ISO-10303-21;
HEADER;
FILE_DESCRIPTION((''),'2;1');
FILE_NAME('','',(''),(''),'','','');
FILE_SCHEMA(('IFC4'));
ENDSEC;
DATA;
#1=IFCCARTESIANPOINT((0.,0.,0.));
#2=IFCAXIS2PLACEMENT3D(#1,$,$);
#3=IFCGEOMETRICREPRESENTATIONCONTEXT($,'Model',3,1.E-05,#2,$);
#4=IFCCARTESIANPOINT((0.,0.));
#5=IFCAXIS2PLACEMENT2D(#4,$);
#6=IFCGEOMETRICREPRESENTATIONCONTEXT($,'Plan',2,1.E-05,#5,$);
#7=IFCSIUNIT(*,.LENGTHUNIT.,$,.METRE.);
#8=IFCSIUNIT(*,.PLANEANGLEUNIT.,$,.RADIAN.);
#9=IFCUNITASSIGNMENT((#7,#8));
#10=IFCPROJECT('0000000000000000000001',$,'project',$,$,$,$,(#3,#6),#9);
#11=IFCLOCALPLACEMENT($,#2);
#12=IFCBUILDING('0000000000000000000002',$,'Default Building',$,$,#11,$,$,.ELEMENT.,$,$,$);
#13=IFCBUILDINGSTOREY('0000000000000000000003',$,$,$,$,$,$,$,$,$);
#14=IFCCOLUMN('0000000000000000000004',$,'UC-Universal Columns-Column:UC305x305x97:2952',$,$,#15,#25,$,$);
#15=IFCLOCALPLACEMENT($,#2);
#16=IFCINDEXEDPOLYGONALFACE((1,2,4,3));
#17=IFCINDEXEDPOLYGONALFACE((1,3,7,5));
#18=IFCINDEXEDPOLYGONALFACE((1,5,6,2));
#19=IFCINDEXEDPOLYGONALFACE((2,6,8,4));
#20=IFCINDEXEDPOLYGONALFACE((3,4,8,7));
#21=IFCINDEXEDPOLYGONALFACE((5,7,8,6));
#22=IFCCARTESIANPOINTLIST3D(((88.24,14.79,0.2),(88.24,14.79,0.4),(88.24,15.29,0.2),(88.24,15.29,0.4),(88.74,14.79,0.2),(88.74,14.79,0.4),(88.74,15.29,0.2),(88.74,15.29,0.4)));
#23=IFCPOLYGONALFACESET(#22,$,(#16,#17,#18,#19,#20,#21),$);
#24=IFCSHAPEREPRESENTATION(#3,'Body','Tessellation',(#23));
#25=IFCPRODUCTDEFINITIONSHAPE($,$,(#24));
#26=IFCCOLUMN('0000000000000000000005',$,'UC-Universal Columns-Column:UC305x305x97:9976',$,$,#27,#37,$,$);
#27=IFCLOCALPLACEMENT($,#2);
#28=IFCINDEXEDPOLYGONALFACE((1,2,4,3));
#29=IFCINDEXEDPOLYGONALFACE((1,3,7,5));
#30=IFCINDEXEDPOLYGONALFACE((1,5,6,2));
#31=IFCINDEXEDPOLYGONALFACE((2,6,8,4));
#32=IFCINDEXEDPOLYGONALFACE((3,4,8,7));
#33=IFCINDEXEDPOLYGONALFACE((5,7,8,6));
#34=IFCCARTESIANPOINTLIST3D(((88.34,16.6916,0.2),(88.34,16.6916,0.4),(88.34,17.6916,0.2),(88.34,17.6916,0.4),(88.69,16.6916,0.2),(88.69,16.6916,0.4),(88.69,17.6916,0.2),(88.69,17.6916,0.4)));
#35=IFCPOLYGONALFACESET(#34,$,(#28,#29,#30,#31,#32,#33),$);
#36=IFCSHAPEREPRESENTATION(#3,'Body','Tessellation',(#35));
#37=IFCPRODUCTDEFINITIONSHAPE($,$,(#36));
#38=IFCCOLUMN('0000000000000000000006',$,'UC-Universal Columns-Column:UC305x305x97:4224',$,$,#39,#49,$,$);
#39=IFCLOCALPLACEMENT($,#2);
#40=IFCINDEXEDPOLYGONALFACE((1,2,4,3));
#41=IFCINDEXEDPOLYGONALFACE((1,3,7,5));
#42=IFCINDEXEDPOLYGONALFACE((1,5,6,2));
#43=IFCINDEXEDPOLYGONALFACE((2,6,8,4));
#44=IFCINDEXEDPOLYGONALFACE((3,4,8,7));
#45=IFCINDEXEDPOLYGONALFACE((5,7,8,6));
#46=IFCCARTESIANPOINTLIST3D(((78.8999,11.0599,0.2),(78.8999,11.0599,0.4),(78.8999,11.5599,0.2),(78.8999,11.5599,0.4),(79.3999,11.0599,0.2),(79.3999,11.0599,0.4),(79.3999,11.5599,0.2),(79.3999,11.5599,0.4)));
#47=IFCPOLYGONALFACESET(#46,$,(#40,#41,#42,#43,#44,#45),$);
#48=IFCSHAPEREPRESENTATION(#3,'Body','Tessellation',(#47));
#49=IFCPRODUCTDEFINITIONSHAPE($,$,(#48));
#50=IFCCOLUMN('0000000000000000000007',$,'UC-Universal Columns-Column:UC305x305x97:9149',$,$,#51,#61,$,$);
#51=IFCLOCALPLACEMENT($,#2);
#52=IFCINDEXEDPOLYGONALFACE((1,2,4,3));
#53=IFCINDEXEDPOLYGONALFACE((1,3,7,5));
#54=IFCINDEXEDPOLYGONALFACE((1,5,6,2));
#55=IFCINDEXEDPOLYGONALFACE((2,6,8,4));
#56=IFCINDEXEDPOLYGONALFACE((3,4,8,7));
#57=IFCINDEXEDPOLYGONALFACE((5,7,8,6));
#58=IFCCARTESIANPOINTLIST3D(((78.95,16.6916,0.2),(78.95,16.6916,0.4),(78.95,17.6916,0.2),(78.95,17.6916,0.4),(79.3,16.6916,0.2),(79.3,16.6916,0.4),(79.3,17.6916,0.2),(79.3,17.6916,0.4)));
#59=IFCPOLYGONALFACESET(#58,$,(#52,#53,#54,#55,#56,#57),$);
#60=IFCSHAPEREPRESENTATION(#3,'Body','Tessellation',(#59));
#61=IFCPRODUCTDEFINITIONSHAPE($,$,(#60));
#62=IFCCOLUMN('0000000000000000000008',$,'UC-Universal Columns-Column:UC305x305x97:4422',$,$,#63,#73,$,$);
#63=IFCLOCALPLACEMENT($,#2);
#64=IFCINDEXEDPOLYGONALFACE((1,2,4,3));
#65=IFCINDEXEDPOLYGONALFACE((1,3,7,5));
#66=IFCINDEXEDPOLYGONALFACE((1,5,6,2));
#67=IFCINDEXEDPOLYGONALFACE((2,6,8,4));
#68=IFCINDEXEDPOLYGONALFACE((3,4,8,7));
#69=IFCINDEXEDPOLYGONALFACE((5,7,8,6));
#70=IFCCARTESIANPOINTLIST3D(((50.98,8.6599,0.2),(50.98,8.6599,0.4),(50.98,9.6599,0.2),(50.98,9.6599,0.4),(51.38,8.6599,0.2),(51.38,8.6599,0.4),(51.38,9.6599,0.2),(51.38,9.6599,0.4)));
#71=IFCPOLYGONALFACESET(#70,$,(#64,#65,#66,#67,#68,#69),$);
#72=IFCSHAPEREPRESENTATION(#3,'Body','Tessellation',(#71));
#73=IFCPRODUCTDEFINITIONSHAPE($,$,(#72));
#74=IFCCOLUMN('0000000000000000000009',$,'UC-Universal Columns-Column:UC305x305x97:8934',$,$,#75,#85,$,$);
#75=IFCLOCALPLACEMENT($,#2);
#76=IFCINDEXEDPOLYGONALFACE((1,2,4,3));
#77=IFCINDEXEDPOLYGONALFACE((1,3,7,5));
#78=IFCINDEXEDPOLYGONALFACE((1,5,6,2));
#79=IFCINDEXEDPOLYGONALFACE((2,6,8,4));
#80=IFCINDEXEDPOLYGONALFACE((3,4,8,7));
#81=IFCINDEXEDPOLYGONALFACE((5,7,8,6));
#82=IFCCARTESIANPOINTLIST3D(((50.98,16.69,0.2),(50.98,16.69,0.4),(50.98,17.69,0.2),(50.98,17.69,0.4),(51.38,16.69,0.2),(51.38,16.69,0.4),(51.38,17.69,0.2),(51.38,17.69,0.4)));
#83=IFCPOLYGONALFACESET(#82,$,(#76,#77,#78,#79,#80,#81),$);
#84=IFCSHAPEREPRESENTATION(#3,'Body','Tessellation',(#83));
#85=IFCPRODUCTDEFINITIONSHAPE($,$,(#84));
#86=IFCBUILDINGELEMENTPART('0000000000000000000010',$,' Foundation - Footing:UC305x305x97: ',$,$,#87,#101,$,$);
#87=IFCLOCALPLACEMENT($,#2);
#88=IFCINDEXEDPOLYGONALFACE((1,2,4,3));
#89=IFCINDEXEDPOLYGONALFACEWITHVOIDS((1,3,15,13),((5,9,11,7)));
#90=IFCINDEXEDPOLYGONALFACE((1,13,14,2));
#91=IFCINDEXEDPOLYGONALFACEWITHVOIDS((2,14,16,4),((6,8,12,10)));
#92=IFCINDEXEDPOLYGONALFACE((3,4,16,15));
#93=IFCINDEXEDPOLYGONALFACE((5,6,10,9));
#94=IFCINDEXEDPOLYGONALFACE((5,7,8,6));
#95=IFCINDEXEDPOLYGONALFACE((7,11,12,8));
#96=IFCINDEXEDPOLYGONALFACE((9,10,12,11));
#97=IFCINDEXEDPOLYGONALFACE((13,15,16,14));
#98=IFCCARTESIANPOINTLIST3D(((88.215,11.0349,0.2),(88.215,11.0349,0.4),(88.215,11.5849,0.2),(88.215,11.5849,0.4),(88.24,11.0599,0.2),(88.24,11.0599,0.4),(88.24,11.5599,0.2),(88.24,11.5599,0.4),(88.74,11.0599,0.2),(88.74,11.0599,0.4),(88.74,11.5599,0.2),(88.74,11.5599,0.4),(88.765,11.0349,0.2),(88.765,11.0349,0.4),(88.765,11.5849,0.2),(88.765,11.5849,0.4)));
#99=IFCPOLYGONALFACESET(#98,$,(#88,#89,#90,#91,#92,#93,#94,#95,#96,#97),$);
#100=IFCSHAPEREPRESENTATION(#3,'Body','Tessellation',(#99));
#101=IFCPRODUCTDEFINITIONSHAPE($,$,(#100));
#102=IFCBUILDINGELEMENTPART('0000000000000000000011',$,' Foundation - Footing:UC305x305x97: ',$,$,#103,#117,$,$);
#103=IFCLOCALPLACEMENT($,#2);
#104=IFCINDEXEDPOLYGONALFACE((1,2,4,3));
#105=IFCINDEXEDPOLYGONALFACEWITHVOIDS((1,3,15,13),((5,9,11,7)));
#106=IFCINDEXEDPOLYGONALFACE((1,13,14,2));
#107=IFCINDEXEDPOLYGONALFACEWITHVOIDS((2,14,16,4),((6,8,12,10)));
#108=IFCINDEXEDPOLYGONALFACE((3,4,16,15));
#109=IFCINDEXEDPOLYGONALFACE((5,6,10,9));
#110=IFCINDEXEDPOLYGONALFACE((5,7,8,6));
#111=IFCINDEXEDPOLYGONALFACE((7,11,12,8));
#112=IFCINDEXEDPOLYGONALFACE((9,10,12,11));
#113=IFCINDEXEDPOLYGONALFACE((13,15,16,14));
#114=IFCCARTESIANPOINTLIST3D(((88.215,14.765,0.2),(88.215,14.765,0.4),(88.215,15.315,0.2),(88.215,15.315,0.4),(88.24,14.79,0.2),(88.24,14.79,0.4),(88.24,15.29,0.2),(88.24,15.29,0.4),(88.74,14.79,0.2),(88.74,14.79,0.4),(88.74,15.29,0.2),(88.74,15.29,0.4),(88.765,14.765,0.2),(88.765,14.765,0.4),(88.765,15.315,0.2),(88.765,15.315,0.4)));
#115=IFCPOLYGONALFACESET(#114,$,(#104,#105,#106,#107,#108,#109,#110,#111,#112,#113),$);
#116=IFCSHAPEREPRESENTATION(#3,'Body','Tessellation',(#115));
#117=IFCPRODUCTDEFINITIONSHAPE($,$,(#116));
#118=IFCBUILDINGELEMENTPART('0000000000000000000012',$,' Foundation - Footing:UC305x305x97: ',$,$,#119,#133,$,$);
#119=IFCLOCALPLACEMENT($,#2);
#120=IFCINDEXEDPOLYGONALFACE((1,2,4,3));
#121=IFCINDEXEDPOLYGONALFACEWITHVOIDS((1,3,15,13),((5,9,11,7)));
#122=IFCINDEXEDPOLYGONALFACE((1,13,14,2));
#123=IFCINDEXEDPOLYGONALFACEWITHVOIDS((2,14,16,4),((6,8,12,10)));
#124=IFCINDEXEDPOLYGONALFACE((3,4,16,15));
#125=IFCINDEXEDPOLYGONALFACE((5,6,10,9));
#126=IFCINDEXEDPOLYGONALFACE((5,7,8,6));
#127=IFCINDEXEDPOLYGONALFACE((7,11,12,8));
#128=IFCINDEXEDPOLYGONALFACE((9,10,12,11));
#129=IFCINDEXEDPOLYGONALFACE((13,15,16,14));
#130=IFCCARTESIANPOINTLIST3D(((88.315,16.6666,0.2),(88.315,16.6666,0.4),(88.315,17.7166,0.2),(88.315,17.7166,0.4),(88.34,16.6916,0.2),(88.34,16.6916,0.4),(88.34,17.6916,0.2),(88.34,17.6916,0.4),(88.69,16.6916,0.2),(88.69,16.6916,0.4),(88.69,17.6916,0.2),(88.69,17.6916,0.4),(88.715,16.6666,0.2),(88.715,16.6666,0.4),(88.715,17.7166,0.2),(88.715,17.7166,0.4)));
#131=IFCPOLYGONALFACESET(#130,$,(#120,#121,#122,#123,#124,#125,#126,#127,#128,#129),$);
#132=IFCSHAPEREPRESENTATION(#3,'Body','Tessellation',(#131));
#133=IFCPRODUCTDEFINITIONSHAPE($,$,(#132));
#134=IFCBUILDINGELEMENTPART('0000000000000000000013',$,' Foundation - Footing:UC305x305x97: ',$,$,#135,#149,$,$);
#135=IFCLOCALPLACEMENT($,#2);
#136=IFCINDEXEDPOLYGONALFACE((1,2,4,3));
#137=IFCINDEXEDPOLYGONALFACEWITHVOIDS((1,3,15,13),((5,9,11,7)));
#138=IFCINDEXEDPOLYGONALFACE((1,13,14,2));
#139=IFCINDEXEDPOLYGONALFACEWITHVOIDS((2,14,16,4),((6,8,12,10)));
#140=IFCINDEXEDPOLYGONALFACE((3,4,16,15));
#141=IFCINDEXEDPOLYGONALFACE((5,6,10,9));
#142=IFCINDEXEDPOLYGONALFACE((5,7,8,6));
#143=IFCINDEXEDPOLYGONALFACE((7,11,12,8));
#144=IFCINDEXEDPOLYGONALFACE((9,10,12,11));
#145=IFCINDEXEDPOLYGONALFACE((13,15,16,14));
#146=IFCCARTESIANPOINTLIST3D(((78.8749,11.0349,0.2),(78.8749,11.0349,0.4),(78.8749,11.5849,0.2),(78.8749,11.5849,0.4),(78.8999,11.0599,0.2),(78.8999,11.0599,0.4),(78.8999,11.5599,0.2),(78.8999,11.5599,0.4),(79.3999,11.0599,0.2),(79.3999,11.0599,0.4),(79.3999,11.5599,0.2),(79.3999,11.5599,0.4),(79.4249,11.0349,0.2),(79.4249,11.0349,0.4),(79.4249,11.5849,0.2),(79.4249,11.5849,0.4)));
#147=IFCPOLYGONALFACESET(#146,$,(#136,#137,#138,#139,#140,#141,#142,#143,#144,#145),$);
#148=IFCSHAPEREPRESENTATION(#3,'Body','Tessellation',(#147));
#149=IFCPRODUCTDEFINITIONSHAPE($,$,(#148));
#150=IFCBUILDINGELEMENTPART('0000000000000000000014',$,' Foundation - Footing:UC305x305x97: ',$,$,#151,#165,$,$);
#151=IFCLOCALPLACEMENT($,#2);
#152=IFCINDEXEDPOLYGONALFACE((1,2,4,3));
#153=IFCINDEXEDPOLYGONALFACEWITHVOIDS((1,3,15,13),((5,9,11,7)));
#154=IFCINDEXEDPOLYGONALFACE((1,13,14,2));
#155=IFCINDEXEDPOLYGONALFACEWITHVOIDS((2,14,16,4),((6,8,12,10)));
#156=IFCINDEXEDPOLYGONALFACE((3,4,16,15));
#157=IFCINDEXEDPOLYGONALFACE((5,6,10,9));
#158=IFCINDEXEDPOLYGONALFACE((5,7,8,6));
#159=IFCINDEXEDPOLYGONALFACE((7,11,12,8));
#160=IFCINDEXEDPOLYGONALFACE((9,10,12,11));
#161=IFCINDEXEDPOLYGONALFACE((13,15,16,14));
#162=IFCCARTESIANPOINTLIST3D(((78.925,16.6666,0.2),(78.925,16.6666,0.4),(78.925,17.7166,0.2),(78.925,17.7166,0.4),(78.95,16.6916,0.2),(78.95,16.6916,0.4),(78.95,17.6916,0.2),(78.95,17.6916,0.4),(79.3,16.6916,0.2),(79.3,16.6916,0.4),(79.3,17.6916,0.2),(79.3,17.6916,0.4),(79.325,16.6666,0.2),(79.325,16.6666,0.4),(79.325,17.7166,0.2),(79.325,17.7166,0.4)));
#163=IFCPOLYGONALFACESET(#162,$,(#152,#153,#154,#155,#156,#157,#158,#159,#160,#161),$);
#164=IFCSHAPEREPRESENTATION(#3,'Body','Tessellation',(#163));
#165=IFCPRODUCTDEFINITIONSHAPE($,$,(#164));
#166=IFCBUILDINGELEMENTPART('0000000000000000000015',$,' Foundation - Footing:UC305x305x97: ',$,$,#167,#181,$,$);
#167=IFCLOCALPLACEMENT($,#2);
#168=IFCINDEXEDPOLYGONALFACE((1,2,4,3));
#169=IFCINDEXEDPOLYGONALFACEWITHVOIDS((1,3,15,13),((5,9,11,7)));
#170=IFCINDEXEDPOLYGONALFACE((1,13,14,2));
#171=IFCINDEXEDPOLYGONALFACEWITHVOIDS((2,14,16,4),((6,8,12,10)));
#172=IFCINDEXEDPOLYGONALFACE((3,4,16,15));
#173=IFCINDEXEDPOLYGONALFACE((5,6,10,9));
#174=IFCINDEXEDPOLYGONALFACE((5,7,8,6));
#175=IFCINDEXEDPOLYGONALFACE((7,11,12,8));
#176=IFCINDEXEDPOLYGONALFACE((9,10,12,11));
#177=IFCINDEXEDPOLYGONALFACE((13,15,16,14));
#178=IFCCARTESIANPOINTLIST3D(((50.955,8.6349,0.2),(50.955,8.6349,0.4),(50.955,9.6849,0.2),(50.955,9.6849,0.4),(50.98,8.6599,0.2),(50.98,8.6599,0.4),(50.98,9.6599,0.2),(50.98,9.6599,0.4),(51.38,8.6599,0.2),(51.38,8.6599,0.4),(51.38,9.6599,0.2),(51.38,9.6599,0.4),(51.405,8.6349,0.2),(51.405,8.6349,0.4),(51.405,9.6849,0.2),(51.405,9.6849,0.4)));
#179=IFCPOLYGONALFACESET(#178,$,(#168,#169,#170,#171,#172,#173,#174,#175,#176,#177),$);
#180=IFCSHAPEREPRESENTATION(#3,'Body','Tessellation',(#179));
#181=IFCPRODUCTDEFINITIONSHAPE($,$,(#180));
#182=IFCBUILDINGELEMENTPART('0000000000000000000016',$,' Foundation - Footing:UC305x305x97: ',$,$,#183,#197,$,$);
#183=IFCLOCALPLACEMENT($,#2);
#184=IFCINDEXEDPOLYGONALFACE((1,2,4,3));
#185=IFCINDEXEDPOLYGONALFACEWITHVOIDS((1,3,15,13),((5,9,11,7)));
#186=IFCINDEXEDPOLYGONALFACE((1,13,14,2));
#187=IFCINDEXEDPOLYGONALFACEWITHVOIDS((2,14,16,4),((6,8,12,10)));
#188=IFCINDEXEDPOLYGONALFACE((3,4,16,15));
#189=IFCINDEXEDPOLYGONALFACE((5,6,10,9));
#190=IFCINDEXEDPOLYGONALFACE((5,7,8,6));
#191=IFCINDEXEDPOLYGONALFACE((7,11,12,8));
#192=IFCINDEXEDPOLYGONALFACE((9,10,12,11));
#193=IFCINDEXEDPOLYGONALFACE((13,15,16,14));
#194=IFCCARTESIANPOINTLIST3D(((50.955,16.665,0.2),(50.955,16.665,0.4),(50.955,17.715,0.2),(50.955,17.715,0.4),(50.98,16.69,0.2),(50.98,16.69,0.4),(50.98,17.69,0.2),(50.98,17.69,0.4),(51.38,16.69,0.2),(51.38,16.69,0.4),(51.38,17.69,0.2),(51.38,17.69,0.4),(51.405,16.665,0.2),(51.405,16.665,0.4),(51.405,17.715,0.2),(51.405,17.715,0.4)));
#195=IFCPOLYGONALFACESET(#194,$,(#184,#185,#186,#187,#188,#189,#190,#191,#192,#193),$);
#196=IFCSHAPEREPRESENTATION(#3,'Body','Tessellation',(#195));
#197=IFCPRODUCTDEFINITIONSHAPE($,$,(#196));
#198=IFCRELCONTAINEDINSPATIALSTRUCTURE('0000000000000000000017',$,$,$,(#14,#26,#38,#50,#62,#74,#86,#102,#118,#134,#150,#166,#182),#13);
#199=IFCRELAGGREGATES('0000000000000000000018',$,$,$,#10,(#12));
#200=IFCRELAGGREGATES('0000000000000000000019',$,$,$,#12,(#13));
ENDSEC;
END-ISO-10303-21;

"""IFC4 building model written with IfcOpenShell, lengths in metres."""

from ifc_helpers import new_model, si_unit, origin, origin_2d, place, context, project, spatial, polyline, outline, extrude, element, save


model = new_model("IFC4")

# Units and contexts
model_context = context("Model", 3, precision=1e-05, world=origin())
plan_context = context("Plan", 2, precision=1e-05, world=origin_2d())
ifc_project = project(units=[si_unit("LENGTHUNIT", "METRE"), si_unit("PLANEANGLEUNIT", "RADIAN")], contexts=[model_context, plan_context])

# Building, storey
building_placement = place(None, origin())
building = spatial("IfcBuilding", under=ifc_project, at=building_placement, Name="Default Building", CompositionType="ELEMENT")
storey = spatial("IfcBuildingStorey", under=building)

# Columns
element("IfcColumn", 1, inside=storey, Name="UC-Universal Columns-Column:UC305x305x97:2952", context=model_context, shape_type="SweptSolid", body=[
    extrude(outline(polyline([(88.74, 15.29, 0.2), (88.24, 15.29, 0.2), (88.24, 14.79, 0.2), (88.74, 14.79, 0.2), (88.74, 15.29, 0.2)])), None, (0.0, 0.0, 1.0), 0.2),
])
element("IfcColumn", 2, inside=storey, Name="UC-Universal Columns-Column:UC305x305x97:9976", context=model_context, shape_type="SweptSolid", body=[
    extrude(outline(polyline([(88.34, 17.6916, 0.2), (88.69, 17.6916, 0.2), (88.69, 16.6916, 0.2), (88.34, 16.6916, 0.2), (88.34, 17.6916, 0.2)])), None, (0.0, 0.0, 1.0), 0.2),
])
element("IfcColumn", 3, inside=storey, Name="UC-Universal Columns-Column:UC305x305x97:4224", context=model_context, shape_type="SweptSolid", body=[
    extrude(outline(polyline([(78.8999, 11.0599, 0.2), (79.3999, 11.0599, 0.2), (79.3999, 11.5599, 0.2), (78.8999, 11.5599, 0.2), (78.8999, 11.0599, 0.2)])), None, (0.0, 0.0, 1.0), 0.2),
])
element("IfcColumn", 4, inside=storey, Name="UC-Universal Columns-Column:UC305x305x97:9149", context=model_context, shape_type="SweptSolid", body=[
    extrude(outline(polyline([(79.3, 17.6916, 0.2), (78.95, 17.6916, 0.2), (78.95, 16.6916, 0.2), (79.3, 16.6916, 0.2), (79.3, 17.6916, 0.2)])), None, (0.0, 0.0, 1.0), 0.2),
])
element("IfcColumn", 5, inside=storey, Name="UC-Universal Columns-Column:UC305x305x97:4422", context=model_context, shape_type="SweptSolid", body=[
    extrude(outline(polyline([(51.38, 8.6599, 0.2), (50.98, 8.6599, 0.2), (50.98, 9.6599, 0.2), (51.38, 9.6599, 0.2), (51.38, 8.6599, 0.2)])), None, (0.0, 0.0, 1.0), 0.2),
])
element("IfcColumn", 6, inside=storey, Name="UC-Universal Columns-Column:UC305x305x97:8934", context=model_context, shape_type="SweptSolid", body=[
    extrude(outline(polyline([(51.38, 17.69, 0.2), (50.98, 17.69, 0.2), (50.98, 16.69, 0.2), (51.38, 16.69, 0.2), (51.38, 17.69, 0.2)])), None, (0.0, 0.0, 1.0), 0.2),
])

# Building element parts, openings
building_element_part_1 = element("IfcBuildingElementPart", 7, inside=storey, Name=" Foundation - Footing:UC305x305x97: ", context=model_context, shape_type="SweptSolid", body=[
    extrude(outline(polyline([(88.765, 11.0349, 0.2), (88.215, 11.0349, 0.2), (88.215, 11.5849, 0.2), (88.765, 11.5849, 0.2), (88.765, 11.0349, 0.2)])), None, (0.0, 0.0, 1.0), 0.2),
])
element("IfcOpeningElement", 8, inside=storey, cuts=building_element_part_1, context=model_context, shape_type="SweptSolid", body=[
    extrude(outline(polyline([(88.74, 11.0599, 0.2), (88.24, 11.0599, 0.2), (88.24, 11.5599, 0.2), (88.74, 11.5599, 0.2), (88.74, 11.0599, 0.2)])), None, (0.0, 0.0, 1.0), 0.2),
])
building_element_part_2 = element("IfcBuildingElementPart", 9, inside=storey, Name=" Foundation - Footing:UC305x305x97: ", context=model_context, shape_type="SweptSolid", body=[
    extrude(outline(polyline([(88.765, 15.315, 0.2), (88.215, 15.315, 0.2), (88.215, 14.765, 0.2), (88.765, 14.765, 0.2), (88.765, 15.315, 0.2)])), None, (0.0, 0.0, 1.0), 0.2),
])
element("IfcOpeningElement", 10, inside=storey, cuts=building_element_part_2, context=model_context, shape_type="SweptSolid", body=[
    extrude(outline(polyline([(88.74, 15.29, 0.2), (88.24, 15.29, 0.2), (88.24, 14.79, 0.2), (88.74, 14.79, 0.2), (88.74, 15.29, 0.2)])), None, (0.0, 0.0, 1.0), 0.2),
])
building_element_part_3 = element("IfcBuildingElementPart", 11, inside=storey, Name=" Foundation - Footing:UC305x305x97: ", context=model_context, shape_type="SweptSolid", body=[
    extrude(outline(polyline([(88.315, 17.7166, 0.2), (88.715, 17.7166, 0.2), (88.715, 16.6666, 0.2), (88.315, 16.6666, 0.2), (88.315, 17.7166, 0.2)])), None, (0.0, 0.0, 1.0), 0.2),
])
element("IfcOpeningElement", 12, inside=storey, cuts=building_element_part_3, context=model_context, shape_type="SweptSolid", body=[
    extrude(outline(polyline([(88.34, 17.6916, 0.2), (88.69, 17.6916, 0.2), (88.69, 16.6916, 0.2), (88.34, 16.6916, 0.2), (88.34, 17.6916, 0.2)])), None, (0.0, 0.0, 1.0), 0.2),
])
building_element_part_4 = element("IfcBuildingElementPart", 13, inside=storey, Name=" Foundation - Footing:UC305x305x97: ", context=model_context, shape_type="SweptSolid", body=[
    extrude(outline(polyline([(78.8749, 11.0349, 0.2), (79.4249, 11.0349, 0.2), (79.4249, 11.5849, 0.2), (78.8749, 11.5849, 0.2), (78.8749, 11.0349, 0.2)])), None, (0.0, 0.0, 1.0), 0.2),
])
element("IfcOpeningElement", 14, inside=storey, cuts=building_element_part_4, context=model_context, shape_type="SweptSolid", body=[
    extrude(outline(polyline([(78.8999, 11.0599, 0.2), (79.3999, 11.0599, 0.2), (79.3999, 11.5599, 0.2), (78.8999, 11.5599, 0.2), (78.8999, 11.0599, 0.2)])), None, (0.0, 0.0, 1.0), 0.2),
])
building_element_part_5 = element("IfcBuildingElementPart", 15, inside=storey, Name=" Foundation - Footing:UC305x305x97: ", context=model_context, shape_type="SweptSolid", body=[
    extrude(outline(polyline([(79.325, 17.7166, 0.2), (78.925, 17.7166, 0.2), (78.925, 16.6666, 0.2), (79.325, 16.6666, 0.2), (79.325, 17.7166, 0.2)])), None, (0.0, 0.0, 1.0), 0.2),
])
element("IfcOpeningElement", 16, inside=storey, cuts=building_element_part_5, context=model_context, shape_type="SweptSolid", body=[
    extrude(outline(polyline([(79.3, 17.6916, 0.2), (78.95, 17.6916, 0.2), (78.95, 16.6916, 0.2), (79.3, 16.6916, 0.2), (79.3, 17.6916, 0.2)])), None, (0.0, 0.0, 1.0), 0.2),
])
building_element_part_6 = element("IfcBuildingElementPart", 17, inside=storey, Name=" Foundation - Footing:UC305x305x97: ", context=model_context, shape_type="SweptSolid", body=[
    extrude(outline(polyline([(51.405, 8.6349, 0.2), (50.955, 8.6349, 0.2), (50.955, 9.6849, 0.2), (51.405, 9.6849, 0.2), (51.405, 8.6349, 0.2)])), None, (0.0, 0.0, 1.0), 0.2),
])
element("IfcOpeningElement", 18, inside=storey, cuts=building_element_part_6, context=model_context, shape_type="SweptSolid", body=[
    extrude(outline(polyline([(51.38, 8.6599, 0.2), (50.98, 8.6599, 0.2), (50.98, 9.6599, 0.2), (51.38, 9.6599, 0.2), (51.38, 8.6599, 0.2)])), None, (0.0, 0.0, 1.0), 0.2),
])
building_element_part_7 = element("IfcBuildingElementPart", 19, inside=storey, Name=" Foundation - Footing:UC305x305x97: ", context=model_context, shape_type="SweptSolid", body=[
    extrude(outline(polyline([(51.405, 17.715, 0.2), (50.955, 17.715, 0.2), (50.955, 16.665, 0.2), (51.405, 16.665, 0.2), (51.405, 17.715, 0.2)])), None, (0.0, 0.0, 1.0), 0.2),
])
element("IfcOpeningElement", 20, inside=storey, cuts=building_element_part_7, context=model_context, shape_type="SweptSolid", body=[
    extrude(outline(polyline([(51.38, 17.69, 0.2), (50.98, 17.69, 0.2), (50.98, 16.69, 0.2), (51.38, 16.69, 0.2), (51.38, 17.69, 0.2)])), None, (0.0, 0.0, 1.0), 0.2),
])

save(model, "model.ifc")
